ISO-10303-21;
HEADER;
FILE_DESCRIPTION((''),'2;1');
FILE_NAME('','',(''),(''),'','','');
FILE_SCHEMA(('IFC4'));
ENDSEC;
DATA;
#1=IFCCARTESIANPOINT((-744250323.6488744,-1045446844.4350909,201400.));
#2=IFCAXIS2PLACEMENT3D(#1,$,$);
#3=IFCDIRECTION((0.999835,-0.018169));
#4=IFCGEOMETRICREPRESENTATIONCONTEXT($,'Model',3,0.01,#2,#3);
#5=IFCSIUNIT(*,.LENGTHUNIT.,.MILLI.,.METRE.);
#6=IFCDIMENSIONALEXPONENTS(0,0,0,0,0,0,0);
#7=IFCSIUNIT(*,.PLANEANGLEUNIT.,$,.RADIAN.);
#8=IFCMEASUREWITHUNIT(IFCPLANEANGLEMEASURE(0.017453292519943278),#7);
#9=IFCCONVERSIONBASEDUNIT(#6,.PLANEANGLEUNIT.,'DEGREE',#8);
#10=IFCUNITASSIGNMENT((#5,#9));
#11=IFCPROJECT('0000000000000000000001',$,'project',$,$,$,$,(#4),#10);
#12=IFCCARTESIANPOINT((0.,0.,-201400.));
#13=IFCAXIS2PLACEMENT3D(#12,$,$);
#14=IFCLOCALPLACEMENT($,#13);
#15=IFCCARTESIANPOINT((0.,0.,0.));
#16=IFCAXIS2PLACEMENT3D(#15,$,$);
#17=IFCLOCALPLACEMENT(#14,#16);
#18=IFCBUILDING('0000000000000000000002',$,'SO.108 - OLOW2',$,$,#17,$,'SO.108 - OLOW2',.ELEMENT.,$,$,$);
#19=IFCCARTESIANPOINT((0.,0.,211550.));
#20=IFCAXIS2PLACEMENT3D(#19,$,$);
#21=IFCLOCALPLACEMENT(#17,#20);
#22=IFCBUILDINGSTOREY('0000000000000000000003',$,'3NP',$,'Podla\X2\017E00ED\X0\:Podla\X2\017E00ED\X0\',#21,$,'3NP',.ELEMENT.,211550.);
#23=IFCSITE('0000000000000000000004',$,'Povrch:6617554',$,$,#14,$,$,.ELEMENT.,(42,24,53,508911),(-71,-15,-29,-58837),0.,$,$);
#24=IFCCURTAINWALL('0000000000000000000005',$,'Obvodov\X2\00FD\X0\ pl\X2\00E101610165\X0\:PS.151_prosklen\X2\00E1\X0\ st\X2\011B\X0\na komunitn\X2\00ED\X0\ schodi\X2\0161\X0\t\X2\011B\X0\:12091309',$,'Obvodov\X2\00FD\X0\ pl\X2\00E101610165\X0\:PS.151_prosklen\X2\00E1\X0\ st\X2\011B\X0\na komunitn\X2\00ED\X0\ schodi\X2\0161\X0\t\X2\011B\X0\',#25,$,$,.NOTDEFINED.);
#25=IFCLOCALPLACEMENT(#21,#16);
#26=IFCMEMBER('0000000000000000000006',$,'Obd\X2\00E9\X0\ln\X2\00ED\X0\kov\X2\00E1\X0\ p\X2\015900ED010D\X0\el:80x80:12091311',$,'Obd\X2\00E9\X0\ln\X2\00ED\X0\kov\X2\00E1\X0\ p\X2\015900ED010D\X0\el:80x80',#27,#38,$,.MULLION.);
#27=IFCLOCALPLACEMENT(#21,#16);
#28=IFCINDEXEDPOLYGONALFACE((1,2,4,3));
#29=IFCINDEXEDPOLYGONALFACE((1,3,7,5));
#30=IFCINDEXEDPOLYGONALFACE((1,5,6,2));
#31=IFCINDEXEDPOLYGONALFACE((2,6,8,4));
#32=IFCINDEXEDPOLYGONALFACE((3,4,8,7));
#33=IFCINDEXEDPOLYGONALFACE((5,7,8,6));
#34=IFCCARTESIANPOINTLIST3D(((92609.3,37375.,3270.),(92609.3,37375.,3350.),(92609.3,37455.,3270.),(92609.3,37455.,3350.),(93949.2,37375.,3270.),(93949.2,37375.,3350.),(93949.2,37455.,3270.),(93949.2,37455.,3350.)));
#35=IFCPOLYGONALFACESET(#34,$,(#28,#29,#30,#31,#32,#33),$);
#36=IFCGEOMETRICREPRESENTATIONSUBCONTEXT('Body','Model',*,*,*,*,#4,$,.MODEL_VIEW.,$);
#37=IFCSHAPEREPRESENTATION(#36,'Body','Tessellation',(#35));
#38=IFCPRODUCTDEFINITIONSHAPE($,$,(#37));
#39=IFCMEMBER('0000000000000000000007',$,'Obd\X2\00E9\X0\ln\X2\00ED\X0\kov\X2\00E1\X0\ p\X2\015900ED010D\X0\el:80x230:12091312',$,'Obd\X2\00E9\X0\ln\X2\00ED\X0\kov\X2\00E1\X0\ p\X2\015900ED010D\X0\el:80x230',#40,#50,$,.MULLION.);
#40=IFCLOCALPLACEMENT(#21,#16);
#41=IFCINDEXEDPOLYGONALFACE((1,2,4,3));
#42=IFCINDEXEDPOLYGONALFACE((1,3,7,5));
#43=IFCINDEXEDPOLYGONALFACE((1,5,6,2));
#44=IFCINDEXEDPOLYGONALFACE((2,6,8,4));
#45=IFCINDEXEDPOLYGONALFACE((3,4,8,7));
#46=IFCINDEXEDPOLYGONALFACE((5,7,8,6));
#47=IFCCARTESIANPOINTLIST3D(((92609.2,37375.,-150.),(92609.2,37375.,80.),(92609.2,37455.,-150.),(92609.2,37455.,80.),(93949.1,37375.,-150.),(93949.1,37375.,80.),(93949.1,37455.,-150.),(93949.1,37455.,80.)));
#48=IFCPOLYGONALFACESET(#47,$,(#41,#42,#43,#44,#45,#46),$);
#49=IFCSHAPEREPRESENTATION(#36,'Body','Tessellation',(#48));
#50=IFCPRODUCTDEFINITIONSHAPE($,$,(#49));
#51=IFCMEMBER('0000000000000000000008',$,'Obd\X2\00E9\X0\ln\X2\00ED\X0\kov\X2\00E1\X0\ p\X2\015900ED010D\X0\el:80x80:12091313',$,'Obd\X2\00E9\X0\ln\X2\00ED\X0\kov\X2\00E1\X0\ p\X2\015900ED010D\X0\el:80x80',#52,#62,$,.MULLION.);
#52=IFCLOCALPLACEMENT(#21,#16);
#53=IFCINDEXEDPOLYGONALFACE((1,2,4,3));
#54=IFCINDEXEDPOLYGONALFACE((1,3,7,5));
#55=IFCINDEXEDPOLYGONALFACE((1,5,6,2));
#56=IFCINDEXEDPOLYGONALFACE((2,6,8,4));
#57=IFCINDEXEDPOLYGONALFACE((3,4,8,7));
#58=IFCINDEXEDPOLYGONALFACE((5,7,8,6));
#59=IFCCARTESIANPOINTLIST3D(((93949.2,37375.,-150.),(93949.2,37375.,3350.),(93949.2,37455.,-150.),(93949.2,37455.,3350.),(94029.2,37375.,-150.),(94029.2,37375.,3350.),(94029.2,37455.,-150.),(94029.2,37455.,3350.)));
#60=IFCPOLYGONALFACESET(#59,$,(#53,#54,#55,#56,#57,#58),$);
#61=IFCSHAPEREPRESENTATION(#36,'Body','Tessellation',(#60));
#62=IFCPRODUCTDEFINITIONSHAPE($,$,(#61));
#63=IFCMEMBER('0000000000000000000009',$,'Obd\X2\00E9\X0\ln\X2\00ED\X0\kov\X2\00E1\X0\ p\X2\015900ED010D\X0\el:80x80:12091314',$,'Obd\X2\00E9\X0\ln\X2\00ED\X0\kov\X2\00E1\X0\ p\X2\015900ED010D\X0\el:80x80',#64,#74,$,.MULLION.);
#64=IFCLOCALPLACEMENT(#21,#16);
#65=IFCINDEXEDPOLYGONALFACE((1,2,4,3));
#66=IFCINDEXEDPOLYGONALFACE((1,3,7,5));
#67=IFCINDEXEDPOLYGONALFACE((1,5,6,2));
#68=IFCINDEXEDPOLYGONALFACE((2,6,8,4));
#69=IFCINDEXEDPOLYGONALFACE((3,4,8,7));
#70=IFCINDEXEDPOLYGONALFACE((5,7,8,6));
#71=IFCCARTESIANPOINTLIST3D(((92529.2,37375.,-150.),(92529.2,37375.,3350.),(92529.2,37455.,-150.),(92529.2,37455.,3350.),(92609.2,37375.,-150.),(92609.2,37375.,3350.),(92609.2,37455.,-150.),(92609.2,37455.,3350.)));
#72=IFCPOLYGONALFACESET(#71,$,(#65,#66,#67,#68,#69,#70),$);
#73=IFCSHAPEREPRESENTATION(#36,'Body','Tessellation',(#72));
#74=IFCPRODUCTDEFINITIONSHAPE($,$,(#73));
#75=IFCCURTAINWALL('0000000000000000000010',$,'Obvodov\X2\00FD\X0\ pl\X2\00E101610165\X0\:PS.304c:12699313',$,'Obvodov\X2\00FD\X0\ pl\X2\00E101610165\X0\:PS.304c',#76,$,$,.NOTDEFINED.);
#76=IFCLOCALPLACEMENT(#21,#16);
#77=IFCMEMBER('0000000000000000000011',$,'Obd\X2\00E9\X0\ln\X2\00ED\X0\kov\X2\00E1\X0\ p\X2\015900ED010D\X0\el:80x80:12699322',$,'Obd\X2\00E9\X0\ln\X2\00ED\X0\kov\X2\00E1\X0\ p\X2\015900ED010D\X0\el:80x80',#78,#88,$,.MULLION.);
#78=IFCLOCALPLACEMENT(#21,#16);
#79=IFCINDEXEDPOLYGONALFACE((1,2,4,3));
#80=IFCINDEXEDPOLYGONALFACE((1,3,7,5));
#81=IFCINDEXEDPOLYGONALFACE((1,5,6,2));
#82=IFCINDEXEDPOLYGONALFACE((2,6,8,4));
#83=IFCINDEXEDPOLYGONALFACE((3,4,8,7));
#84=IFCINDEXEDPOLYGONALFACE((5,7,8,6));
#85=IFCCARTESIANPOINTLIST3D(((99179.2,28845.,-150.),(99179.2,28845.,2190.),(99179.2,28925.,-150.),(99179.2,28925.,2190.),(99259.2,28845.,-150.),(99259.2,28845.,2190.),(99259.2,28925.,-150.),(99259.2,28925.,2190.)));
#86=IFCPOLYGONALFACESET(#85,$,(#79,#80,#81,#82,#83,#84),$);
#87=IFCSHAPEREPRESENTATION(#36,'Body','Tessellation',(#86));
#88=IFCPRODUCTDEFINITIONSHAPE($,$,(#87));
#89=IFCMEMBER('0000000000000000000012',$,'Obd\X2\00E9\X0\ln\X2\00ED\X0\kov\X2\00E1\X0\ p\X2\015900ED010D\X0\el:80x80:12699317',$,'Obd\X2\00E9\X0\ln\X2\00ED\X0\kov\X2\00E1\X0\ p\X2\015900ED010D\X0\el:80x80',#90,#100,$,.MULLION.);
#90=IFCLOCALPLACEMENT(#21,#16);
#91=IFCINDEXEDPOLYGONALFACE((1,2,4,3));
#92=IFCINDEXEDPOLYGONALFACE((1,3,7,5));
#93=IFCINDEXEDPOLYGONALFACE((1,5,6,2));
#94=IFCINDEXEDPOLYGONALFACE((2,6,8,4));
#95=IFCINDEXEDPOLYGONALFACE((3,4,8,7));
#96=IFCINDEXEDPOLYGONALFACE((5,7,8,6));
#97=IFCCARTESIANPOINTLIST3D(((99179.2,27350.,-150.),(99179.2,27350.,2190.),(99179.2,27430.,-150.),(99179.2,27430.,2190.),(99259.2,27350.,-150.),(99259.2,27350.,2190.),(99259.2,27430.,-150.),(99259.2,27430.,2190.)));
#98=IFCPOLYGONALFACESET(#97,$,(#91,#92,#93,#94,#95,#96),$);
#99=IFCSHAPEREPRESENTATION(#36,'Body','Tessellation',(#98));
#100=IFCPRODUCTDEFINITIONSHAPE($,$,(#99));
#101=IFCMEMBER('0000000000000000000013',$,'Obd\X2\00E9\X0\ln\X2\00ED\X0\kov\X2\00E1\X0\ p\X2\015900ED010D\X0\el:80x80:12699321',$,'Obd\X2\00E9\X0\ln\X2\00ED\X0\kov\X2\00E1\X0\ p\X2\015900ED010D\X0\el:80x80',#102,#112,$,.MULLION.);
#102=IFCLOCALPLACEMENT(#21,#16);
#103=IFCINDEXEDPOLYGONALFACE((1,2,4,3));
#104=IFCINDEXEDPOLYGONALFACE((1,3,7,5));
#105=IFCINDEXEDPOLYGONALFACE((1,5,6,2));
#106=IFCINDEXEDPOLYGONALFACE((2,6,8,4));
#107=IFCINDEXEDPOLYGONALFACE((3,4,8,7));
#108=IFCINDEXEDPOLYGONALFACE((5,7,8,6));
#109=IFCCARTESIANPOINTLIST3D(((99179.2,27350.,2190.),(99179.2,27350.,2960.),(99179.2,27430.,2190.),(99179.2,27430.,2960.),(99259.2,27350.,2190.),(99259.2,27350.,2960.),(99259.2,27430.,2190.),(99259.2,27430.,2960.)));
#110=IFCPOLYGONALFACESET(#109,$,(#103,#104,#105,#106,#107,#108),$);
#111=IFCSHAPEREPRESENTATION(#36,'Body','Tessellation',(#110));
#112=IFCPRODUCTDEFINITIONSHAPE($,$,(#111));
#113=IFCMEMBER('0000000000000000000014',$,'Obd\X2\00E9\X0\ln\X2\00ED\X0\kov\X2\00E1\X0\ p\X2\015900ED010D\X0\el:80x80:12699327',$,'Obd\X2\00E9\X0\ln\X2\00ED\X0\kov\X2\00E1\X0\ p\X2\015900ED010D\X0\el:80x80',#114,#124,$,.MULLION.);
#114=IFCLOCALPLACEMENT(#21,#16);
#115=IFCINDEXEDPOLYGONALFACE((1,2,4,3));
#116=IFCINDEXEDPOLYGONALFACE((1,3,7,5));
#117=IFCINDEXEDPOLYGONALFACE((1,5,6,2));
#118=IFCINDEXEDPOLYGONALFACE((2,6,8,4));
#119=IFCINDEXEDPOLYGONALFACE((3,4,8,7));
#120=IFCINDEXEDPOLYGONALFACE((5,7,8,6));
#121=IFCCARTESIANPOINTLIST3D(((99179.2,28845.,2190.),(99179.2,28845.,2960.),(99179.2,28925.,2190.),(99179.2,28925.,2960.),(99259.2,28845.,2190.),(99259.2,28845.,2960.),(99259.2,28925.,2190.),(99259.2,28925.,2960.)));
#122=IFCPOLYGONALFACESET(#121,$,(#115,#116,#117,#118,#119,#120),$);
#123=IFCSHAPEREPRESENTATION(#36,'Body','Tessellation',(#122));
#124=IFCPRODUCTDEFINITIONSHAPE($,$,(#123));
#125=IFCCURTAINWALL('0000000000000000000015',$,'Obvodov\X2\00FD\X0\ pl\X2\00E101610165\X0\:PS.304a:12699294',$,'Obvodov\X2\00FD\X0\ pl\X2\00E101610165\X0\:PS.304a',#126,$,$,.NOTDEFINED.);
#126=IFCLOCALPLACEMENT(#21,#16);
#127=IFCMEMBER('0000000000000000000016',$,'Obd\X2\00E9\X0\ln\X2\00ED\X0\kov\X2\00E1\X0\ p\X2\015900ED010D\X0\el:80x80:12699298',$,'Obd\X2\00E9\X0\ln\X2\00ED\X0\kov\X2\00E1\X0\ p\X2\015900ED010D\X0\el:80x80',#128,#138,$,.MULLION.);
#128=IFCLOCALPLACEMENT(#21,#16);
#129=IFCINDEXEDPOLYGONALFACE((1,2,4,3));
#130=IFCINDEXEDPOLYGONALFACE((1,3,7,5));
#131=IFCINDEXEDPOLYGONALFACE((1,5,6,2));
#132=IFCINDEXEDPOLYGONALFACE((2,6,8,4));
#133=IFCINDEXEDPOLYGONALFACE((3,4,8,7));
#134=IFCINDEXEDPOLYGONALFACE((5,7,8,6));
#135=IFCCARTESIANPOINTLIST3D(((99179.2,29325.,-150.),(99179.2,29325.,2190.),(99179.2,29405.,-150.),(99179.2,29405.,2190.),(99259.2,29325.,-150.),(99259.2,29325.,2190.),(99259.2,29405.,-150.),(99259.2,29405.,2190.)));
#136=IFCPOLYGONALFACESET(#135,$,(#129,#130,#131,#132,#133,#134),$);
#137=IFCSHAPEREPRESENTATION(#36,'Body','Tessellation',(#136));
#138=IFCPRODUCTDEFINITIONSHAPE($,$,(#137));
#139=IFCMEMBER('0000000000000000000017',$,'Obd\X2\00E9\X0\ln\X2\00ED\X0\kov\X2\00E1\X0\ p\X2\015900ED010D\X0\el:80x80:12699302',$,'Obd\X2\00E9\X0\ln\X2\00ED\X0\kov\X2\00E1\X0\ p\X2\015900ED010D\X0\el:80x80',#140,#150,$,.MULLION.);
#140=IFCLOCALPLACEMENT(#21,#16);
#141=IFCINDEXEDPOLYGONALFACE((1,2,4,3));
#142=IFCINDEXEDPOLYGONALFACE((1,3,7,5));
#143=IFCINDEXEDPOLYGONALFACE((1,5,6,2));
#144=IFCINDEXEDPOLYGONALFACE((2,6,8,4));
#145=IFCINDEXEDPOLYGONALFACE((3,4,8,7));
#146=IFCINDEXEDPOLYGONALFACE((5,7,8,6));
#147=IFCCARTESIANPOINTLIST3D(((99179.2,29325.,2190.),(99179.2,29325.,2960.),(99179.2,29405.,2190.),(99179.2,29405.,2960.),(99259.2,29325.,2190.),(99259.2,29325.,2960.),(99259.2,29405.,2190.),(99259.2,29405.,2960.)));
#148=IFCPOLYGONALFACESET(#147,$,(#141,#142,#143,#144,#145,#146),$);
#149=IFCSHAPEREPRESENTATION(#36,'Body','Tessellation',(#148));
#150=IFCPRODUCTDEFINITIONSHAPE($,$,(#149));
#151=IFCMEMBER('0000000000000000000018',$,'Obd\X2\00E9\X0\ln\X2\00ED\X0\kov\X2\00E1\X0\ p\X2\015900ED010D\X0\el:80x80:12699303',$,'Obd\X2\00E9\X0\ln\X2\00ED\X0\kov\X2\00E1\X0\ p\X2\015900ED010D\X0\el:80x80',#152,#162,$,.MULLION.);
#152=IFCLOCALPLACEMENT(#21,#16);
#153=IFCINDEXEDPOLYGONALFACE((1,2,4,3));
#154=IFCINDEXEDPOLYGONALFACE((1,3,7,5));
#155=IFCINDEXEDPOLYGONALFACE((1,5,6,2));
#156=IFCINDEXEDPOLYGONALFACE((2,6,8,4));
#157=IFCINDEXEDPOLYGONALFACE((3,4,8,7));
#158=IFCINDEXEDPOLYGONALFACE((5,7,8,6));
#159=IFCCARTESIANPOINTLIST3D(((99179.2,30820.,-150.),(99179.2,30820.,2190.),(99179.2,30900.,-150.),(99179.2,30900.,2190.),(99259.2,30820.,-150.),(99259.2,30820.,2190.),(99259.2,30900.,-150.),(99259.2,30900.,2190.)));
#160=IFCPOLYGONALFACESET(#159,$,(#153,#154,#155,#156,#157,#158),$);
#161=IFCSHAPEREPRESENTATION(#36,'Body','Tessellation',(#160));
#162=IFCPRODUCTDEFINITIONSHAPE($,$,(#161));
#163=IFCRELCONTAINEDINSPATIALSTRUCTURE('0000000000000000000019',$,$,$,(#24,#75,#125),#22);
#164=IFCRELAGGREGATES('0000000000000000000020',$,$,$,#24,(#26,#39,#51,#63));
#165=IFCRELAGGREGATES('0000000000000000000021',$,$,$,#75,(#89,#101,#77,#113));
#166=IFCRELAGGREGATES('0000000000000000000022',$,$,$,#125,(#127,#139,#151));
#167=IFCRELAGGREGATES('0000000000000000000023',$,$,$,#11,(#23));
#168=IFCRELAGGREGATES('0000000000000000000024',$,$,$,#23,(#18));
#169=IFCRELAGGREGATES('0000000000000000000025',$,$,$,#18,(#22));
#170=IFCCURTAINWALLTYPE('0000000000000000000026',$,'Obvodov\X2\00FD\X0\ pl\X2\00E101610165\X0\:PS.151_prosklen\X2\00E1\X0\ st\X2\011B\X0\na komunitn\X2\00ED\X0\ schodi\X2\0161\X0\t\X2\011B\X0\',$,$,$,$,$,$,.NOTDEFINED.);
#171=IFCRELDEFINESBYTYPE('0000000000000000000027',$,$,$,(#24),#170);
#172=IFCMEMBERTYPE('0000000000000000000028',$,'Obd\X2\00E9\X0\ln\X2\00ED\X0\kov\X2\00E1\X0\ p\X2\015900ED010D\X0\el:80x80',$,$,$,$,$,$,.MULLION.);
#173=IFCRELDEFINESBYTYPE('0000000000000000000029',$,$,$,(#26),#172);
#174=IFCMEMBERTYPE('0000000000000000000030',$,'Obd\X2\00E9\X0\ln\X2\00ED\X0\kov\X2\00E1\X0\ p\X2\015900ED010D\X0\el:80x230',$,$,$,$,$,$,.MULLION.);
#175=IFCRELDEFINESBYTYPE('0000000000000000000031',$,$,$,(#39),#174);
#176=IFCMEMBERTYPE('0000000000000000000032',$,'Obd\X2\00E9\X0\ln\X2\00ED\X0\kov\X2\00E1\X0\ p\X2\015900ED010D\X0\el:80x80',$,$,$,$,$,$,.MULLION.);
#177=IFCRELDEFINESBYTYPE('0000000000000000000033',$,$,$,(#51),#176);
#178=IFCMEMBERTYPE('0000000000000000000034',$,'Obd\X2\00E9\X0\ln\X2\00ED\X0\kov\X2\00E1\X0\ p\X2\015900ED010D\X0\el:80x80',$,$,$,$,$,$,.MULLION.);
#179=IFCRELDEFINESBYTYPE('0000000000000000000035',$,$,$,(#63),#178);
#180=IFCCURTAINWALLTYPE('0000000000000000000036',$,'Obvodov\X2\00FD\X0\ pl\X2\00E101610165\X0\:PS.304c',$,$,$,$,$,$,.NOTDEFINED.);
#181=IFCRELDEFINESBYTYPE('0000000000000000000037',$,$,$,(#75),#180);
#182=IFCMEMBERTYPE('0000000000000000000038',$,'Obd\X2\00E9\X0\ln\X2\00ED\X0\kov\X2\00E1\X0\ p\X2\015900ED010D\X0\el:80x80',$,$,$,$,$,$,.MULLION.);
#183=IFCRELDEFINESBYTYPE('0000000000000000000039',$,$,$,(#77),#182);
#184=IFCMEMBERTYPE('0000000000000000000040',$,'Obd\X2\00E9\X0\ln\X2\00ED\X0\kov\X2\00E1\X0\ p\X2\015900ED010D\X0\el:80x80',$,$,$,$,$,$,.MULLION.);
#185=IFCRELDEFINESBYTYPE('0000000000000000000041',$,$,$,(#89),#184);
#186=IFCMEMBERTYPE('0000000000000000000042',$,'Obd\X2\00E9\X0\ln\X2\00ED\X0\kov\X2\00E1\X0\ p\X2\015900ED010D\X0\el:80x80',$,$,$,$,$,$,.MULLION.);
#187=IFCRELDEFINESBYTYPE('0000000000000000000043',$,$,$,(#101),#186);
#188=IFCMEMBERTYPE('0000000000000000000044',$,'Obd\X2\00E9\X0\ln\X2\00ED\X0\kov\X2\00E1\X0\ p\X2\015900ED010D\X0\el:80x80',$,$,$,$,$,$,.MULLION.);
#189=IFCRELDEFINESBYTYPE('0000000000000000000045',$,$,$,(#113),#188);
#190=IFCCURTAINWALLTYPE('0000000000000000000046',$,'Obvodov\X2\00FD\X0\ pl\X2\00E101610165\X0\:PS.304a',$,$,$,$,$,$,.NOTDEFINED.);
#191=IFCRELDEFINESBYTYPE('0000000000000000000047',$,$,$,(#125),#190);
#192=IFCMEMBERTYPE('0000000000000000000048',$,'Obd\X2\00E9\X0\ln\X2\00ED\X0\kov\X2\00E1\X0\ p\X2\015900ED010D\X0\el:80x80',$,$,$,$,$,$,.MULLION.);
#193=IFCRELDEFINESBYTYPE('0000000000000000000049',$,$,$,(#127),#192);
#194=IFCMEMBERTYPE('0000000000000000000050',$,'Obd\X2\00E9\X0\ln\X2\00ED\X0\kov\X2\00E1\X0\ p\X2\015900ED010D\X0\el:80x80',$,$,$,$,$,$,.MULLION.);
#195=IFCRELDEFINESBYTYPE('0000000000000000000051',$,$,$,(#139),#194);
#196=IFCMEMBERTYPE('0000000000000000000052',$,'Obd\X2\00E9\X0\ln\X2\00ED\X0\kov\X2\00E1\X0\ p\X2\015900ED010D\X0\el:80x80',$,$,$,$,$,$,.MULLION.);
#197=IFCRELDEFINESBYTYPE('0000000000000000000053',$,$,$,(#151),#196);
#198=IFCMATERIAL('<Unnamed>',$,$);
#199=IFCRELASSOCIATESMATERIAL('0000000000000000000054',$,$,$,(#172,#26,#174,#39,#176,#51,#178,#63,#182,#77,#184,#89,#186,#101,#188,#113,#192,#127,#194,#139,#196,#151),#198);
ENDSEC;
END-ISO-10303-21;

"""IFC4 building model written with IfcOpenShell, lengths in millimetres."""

from ifc_helpers import new_model, entity, si_unit, converted_unit, direction, frame, origin, place, context, subcontext, project, spatial, indexed_curve, outline, extrude, source, transform, mapped, material, type_object, type_shapes, element, aggregate, save


model = new_model("IFC4")

# Units and contexts
model_context = context("Model", 3, precision=0.01, world=frame((-744250323.6488744, -1045446844.4350909, 201400.0)), true_north=direction((0.999835, -0.018169)))
body_context = subcontext(model_context, "Body", "Model", "MODEL_VIEW")
ifc_project = project(units=[si_unit("LENGTHUNIT", "METRE", prefix="MILLI"), converted_unit("PLANEANGLEUNIT", "DEGREE", entity("IfcPlaneAngleMeasure", 0.017453292519943278), si_unit("PLANEANGLEUNIT", "RADIAN"), dimensions=[0, 0, 0, 0, 0, 0, 0])], contexts=[model_context])

# Site, building, storey
site_placement = place(None, frame((0.0, 0.0, -201400.0)))
site = spatial("IfcSite", under=ifc_project, at=site_placement, Name="Povrch:6617554", CompositionType="ELEMENT", RefLatitude=(42, 24, 53, 508911), RefLongitude=(-71, -15, -29, -58837), RefElevation=0.0)
building_placement = place(site_placement, origin())
building = spatial("IfcBuilding", under=site, at=building_placement, Name="SO.108 - OLOW2", LongName="SO.108 - OLOW2", CompositionType="ELEMENT")
storey_placement = place(building_placement, frame((0.0, 0.0, 211550.0)))
storey = spatial("IfcBuildingStorey", under=building, at=storey_placement, Name="3NP", ObjectType="Podlaží:Podlaží", LongName="3NP", CompositionType="ELEMENT", Elevation=211550.0)

# Curtain walls, members
curtain_wall_type_1 = type_object("IfcCurtainWallType", Name="Obvodový plášť:PS.151_prosklená stěna komunitní schodiště", PredefinedType="NOTDEFINED")
curtain_wall_1_placement = place(storey_placement, frame((0.0, 0.0, -211550.0)))
curtain_wall_1 = element("IfcCurtainWall", 1, at=curtain_wall_1_placement, inside=storey, type_object=curtain_wall_type_1, Name="Obvodový plášť:PS.151_prosklená stěna komunitní schodiště:12091309", ObjectType="Obvodový plášť:PS.151_prosklená stěna komunitní schodiště", PredefinedType="NOTDEFINED")
ifc_material_1 = material(Name="<Unnamed>")
member_type_1 = type_object("IfcMemberType", Name="Obdélníková příčel:80x80", PredefinedType="MULLION", material=ifc_material_1)
shared_shape_1 = source(origin(), body_context, "Body", "SweptSolid", [
    extrude(outline(indexed_curve([(-40.0, -40.0), (40.0, -40.0), (40.0, 40.0), (-40.0, 40.0), (-40.0, -40.0)], self_intersect=False)), frame((-40.0, 0.0, -1339.9), z_axis=(0.0, 0.0, 1.0), x_axis=(-1.0, 0.0, 0.0)), (0.0, 0.0, 1.0), 1339.9),
])
type_shapes(member_type_1, [shared_shape_1])
member_1_placement = place(curtain_wall_1_placement, frame((93949.2, 37415.0, 214900.0), z_axis=(1.0, 0.0, 0.0), x_axis=(0.0, 0.0, 1.0)))
member_1 = element("IfcMember", 2, at=member_1_placement, type_object=member_type_1, material=ifc_material_1, Name="Obdélníková příčel:80x80:12091311", ObjectType="Obdélníková příčel:80x80", PredefinedType="MULLION", context=body_context, shape_type="MappedRepresentation", body=[
    mapped(shared_shape_1, transform((0.0, 0.0, 0.0), scale=1.0)),
])
member_type_2 = type_object("IfcMemberType", Name="Obdélníková příčel:80x230", PredefinedType="MULLION", material=ifc_material_1)
shared_shape_2 = source(origin(), body_context, "Body", "SweptSolid", [
    extrude(outline(indexed_curve([(-115.0, -40.0), (115.0, -40.0), (115.0, 40.0), (-115.0, 40.0), (-115.0, -40.0)], self_intersect=False)), frame((-115.0, 0.0, -1339.9), z_axis=(0.0, 0.0, 1.0), x_axis=(-1.0, 0.0, 0.0)), (0.0, 0.0, 1.0), 1339.9),
])
type_shapes(member_type_2, [shared_shape_2])
member_2_placement = place(curtain_wall_1_placement, frame((92609.2, 37415.0, 211400.0), z_axis=(-1.0, 0.0, 0.0), x_axis=(0.0, 0.0, -1.0)))
member_2 = element("IfcMember", 3, at=member_2_placement, type_object=member_type_2, material=ifc_material_1, Name="Obdélníková příčel:80x230:12091312", ObjectType="Obdélníková příčel:80x230", PredefinedType="MULLION", context=body_context, shape_type="MappedRepresentation", body=[
    mapped(shared_shape_2, transform((0.0, 0.0, 0.0), scale=1.0)),
])
member_type_3 = type_object("IfcMemberType", Name="Obdélníková příčel:80x80", PredefinedType="MULLION", material=ifc_material_1)
shared_shape_3 = source(origin(), body_context, "Body", "SweptSolid", [
    extrude(outline(indexed_curve([(-40.0, -40.0), (40.0, -40.0), (40.0, 40.0), (-40.0, 40.0), (-40.0, -40.0)], self_intersect=False)), frame((-40.0, 0.0, -3500.0), z_axis=(0.0, 0.0, 1.0), x_axis=(-1.0, 0.0, 0.0)), (0.0, 0.0, 1.0), 3500.0),
])
type_shapes(member_type_3, [shared_shape_3])
member_3_placement = place(curtain_wall_1_placement, frame((94029.2, 37415.0, 211400.0), z_axis=(0.0, 0.0, -1.0), x_axis=(1.0, 0.0, 0.0)))
member_3 = element("IfcMember", 4, at=member_3_placement, type_object=member_type_3, material=ifc_material_1, Name="Obdélníková příčel:80x80:12091313", ObjectType="Obdélníková příčel:80x80", PredefinedType="MULLION", context=body_context, shape_type="MappedRepresentation", body=[
    mapped(shared_shape_3, transform((0.0, 0.0, 0.0), scale=1.0)),
])
member_type_4 = type_object("IfcMemberType", Name="Obdélníková příčel:80x80", PredefinedType="MULLION", material=ifc_material_1)
shared_shape_4 = source(origin(), body_context, "Body", "SweptSolid", [
    extrude(outline(indexed_curve([(-40.0, -40.0), (40.0, -40.0), (40.0, 40.0), (-40.0, 40.0), (-40.0, -40.0)], self_intersect=False)), frame((-40.0, 0.0, -3500.0), z_axis=(0.0, 0.0, 1.0), x_axis=(-1.0, 0.0, 0.0)), (0.0, 0.0, 1.0), 3500.0),
])
type_shapes(member_type_4, [shared_shape_4])
member_4_placement = place(curtain_wall_1_placement, frame((92529.2, 37415.0, 214900.0), z_axis=(0.0, 0.0, 1.0), x_axis=(-1.0, 0.0, 0.0)))
member_4 = element("IfcMember", 5, at=member_4_placement, type_object=member_type_4, material=ifc_material_1, Name="Obdélníková příčel:80x80:12091314", ObjectType="Obdélníková příčel:80x80", PredefinedType="MULLION", context=body_context, shape_type="MappedRepresentation", body=[
    mapped(shared_shape_4, transform((0.0, 0.0, 0.0), scale=1.0)),
])
curtain_wall_type_2 = type_object("IfcCurtainWallType", Name="Obvodový plášť:PS.304c", PredefinedType="NOTDEFINED")
curtain_wall_2_placement = place(storey_placement, frame((0.0, 0.0, -211550.0)))
curtain_wall_2 = element("IfcCurtainWall", 6, at=curtain_wall_2_placement, inside=storey, type_object=curtain_wall_type_2, Name="Obvodový plášť:PS.304c:12699313", ObjectType="Obvodový plášť:PS.304c", PredefinedType="NOTDEFINED")
member_type_5 = type_object("IfcMemberType", Name="Obdélníková příčel:80x80", PredefinedType="MULLION", material=ifc_material_1)
shared_shape_5 = source(origin(), body_context, "Body", "SweptSolid", [
    extrude(outline(indexed_curve([(-40.0, -40.0), (40.0, -40.0), (40.0, 40.0), (-40.0, 40.0), (-40.0, -40.0)], self_intersect=False)), frame((-40.0, 0.0, -2340.0), z_axis=(0.0, 0.0, 1.0), x_axis=(-1.0, 0.0, 0.0)), (0.0, 0.0, 1.0), 2340.0),
])
type_shapes(member_type_5, [shared_shape_5])
member_5_placement = place(curtain_wall_2_placement, frame((99219.2, 28925.0, 213740.0), z_axis=(0.0, 0.0, 1.0), x_axis=(0.0, 1.0, 0.0)))
member_5 = element("IfcMember", 7, at=member_5_placement, type_object=member_type_5, material=ifc_material_1, Name="Obdélníková příčel:80x80:12699322", ObjectType="Obdélníková příčel:80x80", PredefinedType="MULLION", context=body_context, shape_type="MappedRepresentation", body=[
    mapped(shared_shape_5, transform((0.0, 0.0, 0.0), scale=1.0)),
])
member_type_6 = type_object("IfcMemberType", Name="Obdélníková příčel:80x80", PredefinedType="MULLION", material=ifc_material_1)
shared_shape_6 = source(origin(), body_context, "Body", "SweptSolid", [
    extrude(outline(indexed_curve([(-40.0, -40.0), (40.0, -40.0), (40.0, 40.0), (-40.0, 40.0), (-40.0, -40.0)], self_intersect=False)), frame((-40.0, 0.0, -2340.0), z_axis=(0.0, 0.0, 1.0), x_axis=(-1.0, 0.0, 0.0)), (0.0, 0.0, 1.0), 2340.0),
])
type_shapes(member_type_6, [shared_shape_6])
member_6_placement = place(curtain_wall_2_placement, frame((99219.2, 27350.0, 211400.0), z_axis=(0.0, 0.0, -1.0), x_axis=(0.0, -1.0, 0.0)))
member_6 = element("IfcMember", 8, at=member_6_placement, type_object=member_type_6, material=ifc_material_1, Name="Obdélníková příčel:80x80:12699317", ObjectType="Obdélníková příčel:80x80", PredefinedType="MULLION", context=body_context, shape_type="MappedRepresentation", body=[
    mapped(shared_shape_6, transform((0.0, 0.0, 0.0), scale=1.0)),
])
member_type_7 = type_object("IfcMemberType", Name="Obdélníková příčel:80x80", PredefinedType="MULLION", material=ifc_material_1)
shared_shape_7 = source(origin(), body_context, "Body", "SweptSolid", [
    extrude(outline(indexed_curve([(-40.0, -40.0), (40.0, -40.0), (40.0, 40.0), (-40.0, 40.0), (-40.0, -40.0)], self_intersect=False)), frame((-40.0, 0.0, -770.0), z_axis=(0.0, 0.0, 1.0), x_axis=(-1.0, 0.0, 0.0)), (0.0, 0.0, 1.0), 770.0),
])
type_shapes(member_type_7, [shared_shape_7])
member_7_placement = place(curtain_wall_2_placement, frame((99219.2, 27350.0, 213740.0), z_axis=(0.0, 0.0, -1.0), x_axis=(0.0, -1.0, 0.0)))
member_7 = element("IfcMember", 9, at=member_7_placement, type_object=member_type_7, material=ifc_material_1, Name="Obdélníková příčel:80x80:12699321", ObjectType="Obdélníková příčel:80x80", PredefinedType="MULLION", context=body_context, shape_type="MappedRepresentation", body=[
    mapped(shared_shape_7, transform((0.0, 0.0, 0.0), scale=1.0)),
])
member_type_8 = type_object("IfcMemberType", Name="Obdélníková příčel:80x80", PredefinedType="MULLION", material=ifc_material_1)
shared_shape_8 = source(origin(), body_context, "Body", "SweptSolid", [
    extrude(outline(indexed_curve([(-40.0, -40.0), (40.0, -40.0), (40.0, 40.0), (-40.0, 40.0), (-40.0, -40.0)], self_intersect=False)), frame((-40.0, 0.0, -770.0), z_axis=(0.0, 0.0, 1.0), x_axis=(-1.0, 0.0, 0.0)), (0.0, 0.0, 1.0), 770.0),
])
type_shapes(member_type_8, [shared_shape_8])
member_8_placement = place(curtain_wall_2_placement, frame((99219.2, 28925.0, 214510.0), z_axis=(0.0, 0.0, 1.0), x_axis=(0.0, 1.0, 0.0)))
member_8 = element("IfcMember", 10, at=member_8_placement, type_object=member_type_8, material=ifc_material_1, Name="Obdélníková příčel:80x80:12699327", ObjectType="Obdélníková příčel:80x80", PredefinedType="MULLION", context=body_context, shape_type="MappedRepresentation", body=[
    mapped(shared_shape_8, transform((0.0, 0.0, 0.0), scale=1.0)),
])
curtain_wall_type_3 = type_object("IfcCurtainWallType", Name="Obvodový plášť:PS.304a", PredefinedType="NOTDEFINED")
curtain_wall_3_placement = place(storey_placement, frame((0.0, 0.0, -211550.0)))
curtain_wall_3 = element("IfcCurtainWall", 11, at=curtain_wall_3_placement, inside=storey, type_object=curtain_wall_type_3, Name="Obvodový plášť:PS.304a:12699294", ObjectType="Obvodový plášť:PS.304a", PredefinedType="NOTDEFINED")
member_type_9 = type_object("IfcMemberType", Name="Obdélníková příčel:80x80", PredefinedType="MULLION", material=ifc_material_1)
shared_shape_9 = source(origin(), body_context, "Body", "SweptSolid", [
    extrude(outline(indexed_curve([(-40.0, -40.0), (40.0, -40.0), (40.0, 40.0), (-40.0, 40.0), (-40.0, -40.0)], self_intersect=False)), frame((-40.0, 0.0, -2340.0), z_axis=(0.0, 0.0, 1.0), x_axis=(-1.0, 0.0, 0.0)), (0.0, 0.0, 1.0), 2340.0),
])
type_shapes(member_type_9, [shared_shape_9])
member_9_placement = place(curtain_wall_3_placement, frame((99219.2, 29325.0, 211400.0), z_axis=(0.0, 0.0, -1.0), x_axis=(0.0, -1.0, 0.0)))
member_9 = element("IfcMember", 12, at=member_9_placement, type_object=member_type_9, material=ifc_material_1, Name="Obdélníková příčel:80x80:12699298", ObjectType="Obdélníková příčel:80x80", PredefinedType="MULLION", context=body_context, shape_type="MappedRepresentation", body=[
    mapped(shared_shape_9, transform((0.0, 0.0, 0.0), scale=1.0)),
])
member_type_10 = type_object("IfcMemberType", Name="Obdélníková příčel:80x80", PredefinedType="MULLION", material=ifc_material_1)
shared_shape_10 = source(origin(), body_context, "Body", "SweptSolid", [
    extrude(outline(indexed_curve([(-40.0, -40.0), (40.0, -40.0), (40.0, 40.0), (-40.0, 40.0), (-40.0, -40.0)], self_intersect=False)), frame((-40.0, 0.0, -770.0), z_axis=(0.0, 0.0, 1.0), x_axis=(-1.0, 0.0, 0.0)), (0.0, 0.0, 1.0), 770.0),
])
type_shapes(member_type_10, [shared_shape_10])
member_10_placement = place(curtain_wall_3_placement, frame((99219.2, 29325.0, 213740.0), z_axis=(0.0, 0.0, -1.0), x_axis=(0.0, -1.0, 0.0)))
member_10 = element("IfcMember", 13, at=member_10_placement, type_object=member_type_10, material=ifc_material_1, Name="Obdélníková příčel:80x80:12699302", ObjectType="Obdélníková příčel:80x80", PredefinedType="MULLION", context=body_context, shape_type="MappedRepresentation", body=[
    mapped(shared_shape_10, transform((0.0, 0.0, 0.0), scale=1.0)),
])
member_type_11 = type_object("IfcMemberType", Name="Obdélníková příčel:80x80", PredefinedType="MULLION", material=ifc_material_1)
shared_shape_11 = source(origin(), body_context, "Body", "SweptSolid", [
    extrude(outline(indexed_curve([(-40.0, -40.0), (40.0, -40.0), (40.0, 40.0), (-40.0, 40.0), (-40.0, -40.0)], self_intersect=False)), frame((-40.0, 0.0, -2340.0), z_axis=(0.0, 0.0, 1.0), x_axis=(-1.0, 0.0, 0.0)), (0.0, 0.0, 1.0), 2340.0),
])
type_shapes(member_type_11, [shared_shape_11])
member_11_placement = place(curtain_wall_3_placement, frame((99219.2, 30900.0, 213740.0), z_axis=(0.0, 0.0, 1.0), x_axis=(0.0, 1.0, 0.0)))
member_11 = element("IfcMember", 14, at=member_11_placement, type_object=member_type_11, material=ifc_material_1, Name="Obdélníková příčel:80x80:12699303", ObjectType="Obdélníková příčel:80x80", PredefinedType="MULLION", context=body_context, shape_type="MappedRepresentation", body=[
    mapped(shared_shape_11, transform((0.0, 0.0, 0.0), scale=1.0)),
])

aggregate(curtain_wall_1, [member_1, member_2, member_3, member_4])
aggregate(curtain_wall_2, [member_6, member_7, member_5, member_8])

aggregate(curtain_wall_3, [member_9, member_10, member_11])

save(model, "model.ifc")
